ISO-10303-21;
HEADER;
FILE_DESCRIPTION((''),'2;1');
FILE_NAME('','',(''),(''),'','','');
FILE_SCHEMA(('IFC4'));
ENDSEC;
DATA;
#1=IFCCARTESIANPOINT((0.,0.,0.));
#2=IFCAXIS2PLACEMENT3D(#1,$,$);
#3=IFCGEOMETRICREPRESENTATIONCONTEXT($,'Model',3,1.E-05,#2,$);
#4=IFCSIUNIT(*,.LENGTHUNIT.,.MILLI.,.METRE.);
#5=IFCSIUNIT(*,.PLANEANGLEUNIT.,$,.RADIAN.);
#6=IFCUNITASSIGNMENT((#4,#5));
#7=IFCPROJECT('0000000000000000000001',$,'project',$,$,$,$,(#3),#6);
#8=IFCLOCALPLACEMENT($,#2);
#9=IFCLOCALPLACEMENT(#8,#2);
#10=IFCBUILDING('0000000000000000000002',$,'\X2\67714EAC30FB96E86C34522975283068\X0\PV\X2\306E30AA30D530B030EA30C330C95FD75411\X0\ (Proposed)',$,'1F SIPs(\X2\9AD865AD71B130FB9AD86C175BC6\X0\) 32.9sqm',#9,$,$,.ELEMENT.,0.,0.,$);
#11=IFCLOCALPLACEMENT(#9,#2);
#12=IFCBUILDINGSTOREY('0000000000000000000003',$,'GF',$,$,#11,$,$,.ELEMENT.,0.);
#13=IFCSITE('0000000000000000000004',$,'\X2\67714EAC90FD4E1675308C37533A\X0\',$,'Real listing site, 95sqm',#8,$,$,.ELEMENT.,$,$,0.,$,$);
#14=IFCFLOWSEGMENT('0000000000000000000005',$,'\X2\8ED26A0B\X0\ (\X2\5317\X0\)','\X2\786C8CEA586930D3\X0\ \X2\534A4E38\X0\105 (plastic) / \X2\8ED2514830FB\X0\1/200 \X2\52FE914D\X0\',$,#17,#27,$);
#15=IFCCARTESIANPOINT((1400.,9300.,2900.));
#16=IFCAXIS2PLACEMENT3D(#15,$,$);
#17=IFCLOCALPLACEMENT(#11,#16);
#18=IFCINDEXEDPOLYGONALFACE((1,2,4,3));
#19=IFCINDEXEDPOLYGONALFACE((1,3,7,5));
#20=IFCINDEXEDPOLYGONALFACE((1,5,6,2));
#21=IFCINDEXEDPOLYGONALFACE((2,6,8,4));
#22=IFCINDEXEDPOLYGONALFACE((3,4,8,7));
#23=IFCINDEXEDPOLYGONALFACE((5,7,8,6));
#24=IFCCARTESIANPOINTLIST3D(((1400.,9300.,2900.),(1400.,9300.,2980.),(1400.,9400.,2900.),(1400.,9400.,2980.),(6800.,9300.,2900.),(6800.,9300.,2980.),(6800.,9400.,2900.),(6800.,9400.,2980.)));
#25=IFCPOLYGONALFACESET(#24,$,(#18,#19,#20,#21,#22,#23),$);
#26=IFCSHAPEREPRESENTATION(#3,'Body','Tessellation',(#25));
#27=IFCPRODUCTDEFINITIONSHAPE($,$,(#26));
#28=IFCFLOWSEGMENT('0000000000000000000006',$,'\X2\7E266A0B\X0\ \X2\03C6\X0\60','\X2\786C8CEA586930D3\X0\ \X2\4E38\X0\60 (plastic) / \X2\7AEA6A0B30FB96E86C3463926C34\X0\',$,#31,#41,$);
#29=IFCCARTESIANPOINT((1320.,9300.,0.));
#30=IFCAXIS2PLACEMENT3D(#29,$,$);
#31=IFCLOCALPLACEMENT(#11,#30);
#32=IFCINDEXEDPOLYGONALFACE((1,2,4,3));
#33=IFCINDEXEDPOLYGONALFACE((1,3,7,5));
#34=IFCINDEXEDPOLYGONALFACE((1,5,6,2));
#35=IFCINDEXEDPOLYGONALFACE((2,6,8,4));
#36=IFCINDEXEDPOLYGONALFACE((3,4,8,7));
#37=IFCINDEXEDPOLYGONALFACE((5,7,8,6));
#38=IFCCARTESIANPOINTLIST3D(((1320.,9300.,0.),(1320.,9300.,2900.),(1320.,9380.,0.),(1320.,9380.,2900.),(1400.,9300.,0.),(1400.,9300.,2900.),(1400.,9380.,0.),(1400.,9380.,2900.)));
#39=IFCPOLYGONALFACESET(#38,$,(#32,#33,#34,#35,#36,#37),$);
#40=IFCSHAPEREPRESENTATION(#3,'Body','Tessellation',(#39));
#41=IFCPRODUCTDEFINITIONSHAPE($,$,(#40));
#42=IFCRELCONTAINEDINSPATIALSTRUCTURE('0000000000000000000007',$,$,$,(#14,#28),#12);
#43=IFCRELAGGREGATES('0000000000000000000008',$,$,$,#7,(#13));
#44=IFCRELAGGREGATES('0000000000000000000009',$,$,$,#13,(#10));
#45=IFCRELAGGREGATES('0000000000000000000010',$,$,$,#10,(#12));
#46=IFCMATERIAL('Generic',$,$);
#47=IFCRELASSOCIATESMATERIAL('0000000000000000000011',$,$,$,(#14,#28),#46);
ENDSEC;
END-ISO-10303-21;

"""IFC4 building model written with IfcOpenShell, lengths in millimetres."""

from ifc_helpers import new_model, si_unit, frame, frame_2d, origin, place, context, project, spatial, rectangle, extrude, material, element, save


model = new_model("IFC4")

# Units and contexts
model_context = context("Model", 3, precision=1e-05, world=origin())
ifc_project = project(units=[si_unit("LENGTHUNIT", "METRE", prefix="MILLI"), si_unit("PLANEANGLEUNIT", "RADIAN")], contexts=[model_context])

# Site, building, storey
site_placement = place(None, origin())
site = spatial("IfcSite", under=ifc_project, at=site_placement, Name="東京都世田谷区", ObjectType="Real listing site, 95sqm", CompositionType="ELEMENT", RefElevation=0.0)
building_placement = place(site_placement, origin())
building = spatial("IfcBuilding", under=site, at=building_placement, Name="東京・雨水利用とPVのオフグリッド志向 (Proposed)", ObjectType="1F SIPs(高断熱・高気密) 32.9sqm", CompositionType="ELEMENT", ElevationOfRefHeight=0.0, ElevationOfTerrain=0.0)
storey_placement = place(building_placement, origin())
storey = spatial("IfcBuildingStorey", under=building, at=storey_placement, Name="GF", CompositionType="ELEMENT", Elevation=0.0)

# Shared definitions
ifc_material_1 = material(Name="Generic")

# Flow segments
flow_segment_1_placement = place(storey_placement, frame((1400.0, 9300.0, 2900.0)))
element("IfcFlowSegment", 1, at=flow_segment_1_placement, inside=storey, material=ifc_material_1, Name="軒樋 (北)", Description="硬質塩ビ 半丸105 (plastic) / 軒先・1/200 勾配", context=model_context, shape_type="SweptSolid", body=[
    extrude(rectangle(XDim=5400.0, YDim=100.0, at=frame_2d((2700.0, 50.0))), frame((1400.0, 9300.0, 2900.0)), (0.0, 0.0, 1.0), 80.0),
])
flow_segment_2_placement = place(storey_placement, frame((1320.0, 9300.0, 0.0)))
element("IfcFlowSegment", 2, at=flow_segment_2_placement, inside=storey, material=ifc_material_1, Name="縦樋 φ60", Description="硬質塩ビ 丸60 (plastic) / 竪樋・雨水排水", context=model_context, shape_type="SweptSolid", body=[
    extrude(rectangle(XDim=80.0, YDim=80.0, at=frame_2d((40.0, 40.0))), frame((1320.0, 9300.0, 0.0)), (0.0, 0.0, 1.0), 2900.0),
])

save(model, "model.ifc")
